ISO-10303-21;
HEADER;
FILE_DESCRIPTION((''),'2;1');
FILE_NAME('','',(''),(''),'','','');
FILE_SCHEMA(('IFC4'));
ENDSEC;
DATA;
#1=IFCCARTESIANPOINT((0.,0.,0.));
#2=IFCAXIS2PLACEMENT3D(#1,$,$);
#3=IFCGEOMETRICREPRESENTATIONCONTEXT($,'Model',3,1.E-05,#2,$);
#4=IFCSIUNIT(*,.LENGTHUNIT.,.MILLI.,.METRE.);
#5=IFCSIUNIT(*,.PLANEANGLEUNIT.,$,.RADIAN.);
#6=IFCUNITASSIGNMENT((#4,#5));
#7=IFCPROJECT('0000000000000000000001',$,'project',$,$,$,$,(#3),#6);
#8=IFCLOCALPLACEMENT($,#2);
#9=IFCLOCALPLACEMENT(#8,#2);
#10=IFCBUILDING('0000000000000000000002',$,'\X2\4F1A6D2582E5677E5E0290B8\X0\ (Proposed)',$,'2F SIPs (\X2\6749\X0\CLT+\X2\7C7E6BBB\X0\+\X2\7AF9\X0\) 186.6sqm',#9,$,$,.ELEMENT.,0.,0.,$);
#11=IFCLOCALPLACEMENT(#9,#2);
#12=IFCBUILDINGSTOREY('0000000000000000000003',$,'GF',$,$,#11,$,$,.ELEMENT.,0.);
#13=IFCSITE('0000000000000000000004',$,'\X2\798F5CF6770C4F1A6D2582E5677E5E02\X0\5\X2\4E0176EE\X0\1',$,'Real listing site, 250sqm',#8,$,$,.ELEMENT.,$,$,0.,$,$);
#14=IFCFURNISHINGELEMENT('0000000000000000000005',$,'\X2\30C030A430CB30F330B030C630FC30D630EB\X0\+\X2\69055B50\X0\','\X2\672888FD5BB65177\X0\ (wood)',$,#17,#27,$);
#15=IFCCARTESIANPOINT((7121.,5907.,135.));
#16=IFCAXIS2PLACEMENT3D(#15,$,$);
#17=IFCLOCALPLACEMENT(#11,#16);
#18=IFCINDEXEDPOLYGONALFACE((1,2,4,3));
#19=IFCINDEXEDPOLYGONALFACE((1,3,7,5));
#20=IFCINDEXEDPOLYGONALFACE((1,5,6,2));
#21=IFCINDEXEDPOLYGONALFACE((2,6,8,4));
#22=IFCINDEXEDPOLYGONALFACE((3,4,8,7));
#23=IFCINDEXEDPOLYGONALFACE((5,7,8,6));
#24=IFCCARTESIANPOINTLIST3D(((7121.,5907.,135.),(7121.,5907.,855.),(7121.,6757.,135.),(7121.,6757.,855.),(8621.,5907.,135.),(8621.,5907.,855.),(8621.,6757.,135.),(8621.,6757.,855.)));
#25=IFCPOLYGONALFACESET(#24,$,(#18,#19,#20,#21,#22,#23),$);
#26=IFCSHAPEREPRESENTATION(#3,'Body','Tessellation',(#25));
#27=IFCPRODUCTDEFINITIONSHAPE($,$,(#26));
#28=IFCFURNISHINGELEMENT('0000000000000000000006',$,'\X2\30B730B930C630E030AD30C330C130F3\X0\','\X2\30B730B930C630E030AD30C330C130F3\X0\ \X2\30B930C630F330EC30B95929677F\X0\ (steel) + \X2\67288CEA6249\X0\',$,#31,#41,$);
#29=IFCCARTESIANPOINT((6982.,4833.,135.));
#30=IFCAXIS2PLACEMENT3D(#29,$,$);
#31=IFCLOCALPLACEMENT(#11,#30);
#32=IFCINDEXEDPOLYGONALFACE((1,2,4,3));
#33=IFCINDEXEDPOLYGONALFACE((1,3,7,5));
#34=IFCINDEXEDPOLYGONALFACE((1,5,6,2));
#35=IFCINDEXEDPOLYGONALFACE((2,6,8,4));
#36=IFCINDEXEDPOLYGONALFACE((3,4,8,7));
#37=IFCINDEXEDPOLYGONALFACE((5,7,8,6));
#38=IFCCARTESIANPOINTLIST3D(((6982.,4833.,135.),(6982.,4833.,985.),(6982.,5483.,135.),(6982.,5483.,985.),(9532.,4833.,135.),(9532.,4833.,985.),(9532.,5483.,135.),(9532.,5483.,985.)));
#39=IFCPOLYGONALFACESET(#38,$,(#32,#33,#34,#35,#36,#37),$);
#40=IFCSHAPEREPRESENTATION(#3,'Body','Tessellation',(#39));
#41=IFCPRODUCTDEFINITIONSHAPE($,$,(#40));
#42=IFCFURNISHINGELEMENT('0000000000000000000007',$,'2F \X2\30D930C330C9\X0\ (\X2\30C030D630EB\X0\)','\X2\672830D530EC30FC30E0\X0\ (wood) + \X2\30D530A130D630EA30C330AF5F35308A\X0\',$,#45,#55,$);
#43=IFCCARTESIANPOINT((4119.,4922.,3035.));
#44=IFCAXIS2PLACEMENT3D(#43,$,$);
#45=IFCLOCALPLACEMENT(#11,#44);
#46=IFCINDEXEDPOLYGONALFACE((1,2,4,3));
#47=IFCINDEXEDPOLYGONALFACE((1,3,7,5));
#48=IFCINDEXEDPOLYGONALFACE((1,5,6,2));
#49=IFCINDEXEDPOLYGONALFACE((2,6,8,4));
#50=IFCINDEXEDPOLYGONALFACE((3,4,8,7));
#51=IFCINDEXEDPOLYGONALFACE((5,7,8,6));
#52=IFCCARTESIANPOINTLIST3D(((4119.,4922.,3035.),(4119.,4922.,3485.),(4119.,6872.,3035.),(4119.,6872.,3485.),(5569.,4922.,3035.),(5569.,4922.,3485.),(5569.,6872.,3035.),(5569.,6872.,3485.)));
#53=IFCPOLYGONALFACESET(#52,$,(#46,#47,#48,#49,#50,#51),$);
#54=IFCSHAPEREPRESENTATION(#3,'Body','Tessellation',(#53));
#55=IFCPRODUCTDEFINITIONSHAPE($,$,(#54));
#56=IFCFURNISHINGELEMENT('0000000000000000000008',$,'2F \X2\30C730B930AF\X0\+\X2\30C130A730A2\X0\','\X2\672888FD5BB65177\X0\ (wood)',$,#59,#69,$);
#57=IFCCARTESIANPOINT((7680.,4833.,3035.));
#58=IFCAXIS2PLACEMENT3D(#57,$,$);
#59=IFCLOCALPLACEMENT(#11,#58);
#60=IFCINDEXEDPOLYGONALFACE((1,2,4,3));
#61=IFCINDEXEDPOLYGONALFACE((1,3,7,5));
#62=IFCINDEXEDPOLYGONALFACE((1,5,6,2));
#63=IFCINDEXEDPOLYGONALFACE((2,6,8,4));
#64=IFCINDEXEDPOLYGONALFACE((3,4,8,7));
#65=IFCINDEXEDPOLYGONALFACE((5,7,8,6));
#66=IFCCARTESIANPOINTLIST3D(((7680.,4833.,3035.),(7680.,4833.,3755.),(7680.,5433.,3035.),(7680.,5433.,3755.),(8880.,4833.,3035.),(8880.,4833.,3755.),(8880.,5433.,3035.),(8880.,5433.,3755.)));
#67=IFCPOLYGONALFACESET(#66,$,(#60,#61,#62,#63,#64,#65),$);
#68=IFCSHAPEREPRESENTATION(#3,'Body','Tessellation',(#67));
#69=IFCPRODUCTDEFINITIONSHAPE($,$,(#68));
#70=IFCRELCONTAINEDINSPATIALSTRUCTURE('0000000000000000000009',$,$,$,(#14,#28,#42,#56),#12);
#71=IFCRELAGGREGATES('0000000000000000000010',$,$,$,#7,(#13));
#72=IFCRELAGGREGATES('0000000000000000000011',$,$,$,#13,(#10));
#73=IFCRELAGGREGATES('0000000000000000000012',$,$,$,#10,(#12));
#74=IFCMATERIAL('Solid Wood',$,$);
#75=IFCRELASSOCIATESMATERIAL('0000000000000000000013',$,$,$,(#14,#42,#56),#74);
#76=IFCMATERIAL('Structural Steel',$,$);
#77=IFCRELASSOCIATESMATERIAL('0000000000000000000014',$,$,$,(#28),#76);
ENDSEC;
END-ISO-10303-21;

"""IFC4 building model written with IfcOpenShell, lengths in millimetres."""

from ifc_helpers import new_model, si_unit, frame, frame_2d, origin, place, context, project, spatial, rectangle, extrude, material, element, save


model = new_model("IFC4")

# Units and contexts
model_context = context("Model", 3, precision=1e-05, world=origin())
ifc_project = project(units=[si_unit("LENGTHUNIT", "METRE", prefix="MILLI"), si_unit("PLANEANGLEUNIT", "RADIAN")], contexts=[model_context])

# Site, building, storey
site_placement = place(None, origin())
site = spatial("IfcSite", under=ifc_project, at=site_placement, Name="福島県会津若松市5丁目1", ObjectType="Real listing site, 250sqm", CompositionType="ELEMENT", RefElevation=0.0)
building_placement = place(site_placement, origin())
building = spatial("IfcBuilding", under=site, at=building_placement, Name="会津若松市邸 (Proposed)", ObjectType="2F SIPs (杉CLT+籾殻+竹) 186.6sqm", CompositionType="ELEMENT", ElevationOfRefHeight=0.0, ElevationOfTerrain=0.0)
storey_placement = place(building_placement, origin())
storey = spatial("IfcBuildingStorey", under=building, at=storey_placement, Name="GF", CompositionType="ELEMENT", Elevation=0.0)

# Shared definitions
ifc_material_1 = material(Name="Solid Wood")

# Shared definitions
ifc_material_2 = material(Name="Structural Steel")

# Furnishing elements
furnishing_1_placement = place(storey_placement, frame((7121.0, 5907.0, 135.0)))
element("IfcFurnishingElement", 1, at=furnishing_1_placement, inside=storey, material=ifc_material_1, Name="ダイニングテーブル+椅子", Description="木製家具 (wood)", context=model_context, shape_type="SweptSolid", body=[
    extrude(rectangle(XDim=1500.0, YDim=850.0, at=frame_2d((750.0, 425.0))), frame((7121.0, 5907.0, 135.0)), (0.0, 0.0, 1.0), 720.0),
])
furnishing_2_placement = place(storey_placement, frame((6982.0, 4833.0, 135.0)))
element("IfcFurnishingElement", 2, at=furnishing_2_placement, inside=storey, material=ifc_material_2, Name="システムキッチン", Description="システムキッチン ステンレス天板 (steel) + 木質扉", context=model_context, shape_type="SweptSolid", body=[
    extrude(rectangle(XDim=2550.0, YDim=650.0, at=frame_2d((1275.0, 325.0))), frame((6982.0, 4833.0, 135.0)), (0.0, 0.0, 1.0), 850.0),
])
furnishing_3_placement = place(storey_placement, frame((4119.0, 4922.0, 3035.0)))
element("IfcFurnishingElement", 3, at=furnishing_3_placement, inside=storey, material=ifc_material_1, Name="2F ベッド (ダブル)", Description="木フレーム (wood) + ファブリック張り", context=model_context, shape_type="SweptSolid", body=[
    extrude(rectangle(XDim=1450.0, YDim=1950.0, at=frame_2d((725.0, 975.0))), frame((4119.0, 4922.0, 3035.0)), (0.0, 0.0, 1.0), 450.0),
])
furnishing_4_placement = place(storey_placement, frame((7680.0, 4833.0, 3035.0)))
element("IfcFurnishingElement", 4, at=furnishing_4_placement, inside=storey, material=ifc_material_1, Name="2F デスク+チェア", Description="木製家具 (wood)", context=model_context, shape_type="SweptSolid", body=[
    extrude(rectangle(XDim=1200.0, YDim=600.0, at=frame_2d((600.0, 300.0))), frame((7680.0, 4833.0, 3035.0)), (0.0, 0.0, 1.0), 720.0),
])

save(model, "model.ifc")
